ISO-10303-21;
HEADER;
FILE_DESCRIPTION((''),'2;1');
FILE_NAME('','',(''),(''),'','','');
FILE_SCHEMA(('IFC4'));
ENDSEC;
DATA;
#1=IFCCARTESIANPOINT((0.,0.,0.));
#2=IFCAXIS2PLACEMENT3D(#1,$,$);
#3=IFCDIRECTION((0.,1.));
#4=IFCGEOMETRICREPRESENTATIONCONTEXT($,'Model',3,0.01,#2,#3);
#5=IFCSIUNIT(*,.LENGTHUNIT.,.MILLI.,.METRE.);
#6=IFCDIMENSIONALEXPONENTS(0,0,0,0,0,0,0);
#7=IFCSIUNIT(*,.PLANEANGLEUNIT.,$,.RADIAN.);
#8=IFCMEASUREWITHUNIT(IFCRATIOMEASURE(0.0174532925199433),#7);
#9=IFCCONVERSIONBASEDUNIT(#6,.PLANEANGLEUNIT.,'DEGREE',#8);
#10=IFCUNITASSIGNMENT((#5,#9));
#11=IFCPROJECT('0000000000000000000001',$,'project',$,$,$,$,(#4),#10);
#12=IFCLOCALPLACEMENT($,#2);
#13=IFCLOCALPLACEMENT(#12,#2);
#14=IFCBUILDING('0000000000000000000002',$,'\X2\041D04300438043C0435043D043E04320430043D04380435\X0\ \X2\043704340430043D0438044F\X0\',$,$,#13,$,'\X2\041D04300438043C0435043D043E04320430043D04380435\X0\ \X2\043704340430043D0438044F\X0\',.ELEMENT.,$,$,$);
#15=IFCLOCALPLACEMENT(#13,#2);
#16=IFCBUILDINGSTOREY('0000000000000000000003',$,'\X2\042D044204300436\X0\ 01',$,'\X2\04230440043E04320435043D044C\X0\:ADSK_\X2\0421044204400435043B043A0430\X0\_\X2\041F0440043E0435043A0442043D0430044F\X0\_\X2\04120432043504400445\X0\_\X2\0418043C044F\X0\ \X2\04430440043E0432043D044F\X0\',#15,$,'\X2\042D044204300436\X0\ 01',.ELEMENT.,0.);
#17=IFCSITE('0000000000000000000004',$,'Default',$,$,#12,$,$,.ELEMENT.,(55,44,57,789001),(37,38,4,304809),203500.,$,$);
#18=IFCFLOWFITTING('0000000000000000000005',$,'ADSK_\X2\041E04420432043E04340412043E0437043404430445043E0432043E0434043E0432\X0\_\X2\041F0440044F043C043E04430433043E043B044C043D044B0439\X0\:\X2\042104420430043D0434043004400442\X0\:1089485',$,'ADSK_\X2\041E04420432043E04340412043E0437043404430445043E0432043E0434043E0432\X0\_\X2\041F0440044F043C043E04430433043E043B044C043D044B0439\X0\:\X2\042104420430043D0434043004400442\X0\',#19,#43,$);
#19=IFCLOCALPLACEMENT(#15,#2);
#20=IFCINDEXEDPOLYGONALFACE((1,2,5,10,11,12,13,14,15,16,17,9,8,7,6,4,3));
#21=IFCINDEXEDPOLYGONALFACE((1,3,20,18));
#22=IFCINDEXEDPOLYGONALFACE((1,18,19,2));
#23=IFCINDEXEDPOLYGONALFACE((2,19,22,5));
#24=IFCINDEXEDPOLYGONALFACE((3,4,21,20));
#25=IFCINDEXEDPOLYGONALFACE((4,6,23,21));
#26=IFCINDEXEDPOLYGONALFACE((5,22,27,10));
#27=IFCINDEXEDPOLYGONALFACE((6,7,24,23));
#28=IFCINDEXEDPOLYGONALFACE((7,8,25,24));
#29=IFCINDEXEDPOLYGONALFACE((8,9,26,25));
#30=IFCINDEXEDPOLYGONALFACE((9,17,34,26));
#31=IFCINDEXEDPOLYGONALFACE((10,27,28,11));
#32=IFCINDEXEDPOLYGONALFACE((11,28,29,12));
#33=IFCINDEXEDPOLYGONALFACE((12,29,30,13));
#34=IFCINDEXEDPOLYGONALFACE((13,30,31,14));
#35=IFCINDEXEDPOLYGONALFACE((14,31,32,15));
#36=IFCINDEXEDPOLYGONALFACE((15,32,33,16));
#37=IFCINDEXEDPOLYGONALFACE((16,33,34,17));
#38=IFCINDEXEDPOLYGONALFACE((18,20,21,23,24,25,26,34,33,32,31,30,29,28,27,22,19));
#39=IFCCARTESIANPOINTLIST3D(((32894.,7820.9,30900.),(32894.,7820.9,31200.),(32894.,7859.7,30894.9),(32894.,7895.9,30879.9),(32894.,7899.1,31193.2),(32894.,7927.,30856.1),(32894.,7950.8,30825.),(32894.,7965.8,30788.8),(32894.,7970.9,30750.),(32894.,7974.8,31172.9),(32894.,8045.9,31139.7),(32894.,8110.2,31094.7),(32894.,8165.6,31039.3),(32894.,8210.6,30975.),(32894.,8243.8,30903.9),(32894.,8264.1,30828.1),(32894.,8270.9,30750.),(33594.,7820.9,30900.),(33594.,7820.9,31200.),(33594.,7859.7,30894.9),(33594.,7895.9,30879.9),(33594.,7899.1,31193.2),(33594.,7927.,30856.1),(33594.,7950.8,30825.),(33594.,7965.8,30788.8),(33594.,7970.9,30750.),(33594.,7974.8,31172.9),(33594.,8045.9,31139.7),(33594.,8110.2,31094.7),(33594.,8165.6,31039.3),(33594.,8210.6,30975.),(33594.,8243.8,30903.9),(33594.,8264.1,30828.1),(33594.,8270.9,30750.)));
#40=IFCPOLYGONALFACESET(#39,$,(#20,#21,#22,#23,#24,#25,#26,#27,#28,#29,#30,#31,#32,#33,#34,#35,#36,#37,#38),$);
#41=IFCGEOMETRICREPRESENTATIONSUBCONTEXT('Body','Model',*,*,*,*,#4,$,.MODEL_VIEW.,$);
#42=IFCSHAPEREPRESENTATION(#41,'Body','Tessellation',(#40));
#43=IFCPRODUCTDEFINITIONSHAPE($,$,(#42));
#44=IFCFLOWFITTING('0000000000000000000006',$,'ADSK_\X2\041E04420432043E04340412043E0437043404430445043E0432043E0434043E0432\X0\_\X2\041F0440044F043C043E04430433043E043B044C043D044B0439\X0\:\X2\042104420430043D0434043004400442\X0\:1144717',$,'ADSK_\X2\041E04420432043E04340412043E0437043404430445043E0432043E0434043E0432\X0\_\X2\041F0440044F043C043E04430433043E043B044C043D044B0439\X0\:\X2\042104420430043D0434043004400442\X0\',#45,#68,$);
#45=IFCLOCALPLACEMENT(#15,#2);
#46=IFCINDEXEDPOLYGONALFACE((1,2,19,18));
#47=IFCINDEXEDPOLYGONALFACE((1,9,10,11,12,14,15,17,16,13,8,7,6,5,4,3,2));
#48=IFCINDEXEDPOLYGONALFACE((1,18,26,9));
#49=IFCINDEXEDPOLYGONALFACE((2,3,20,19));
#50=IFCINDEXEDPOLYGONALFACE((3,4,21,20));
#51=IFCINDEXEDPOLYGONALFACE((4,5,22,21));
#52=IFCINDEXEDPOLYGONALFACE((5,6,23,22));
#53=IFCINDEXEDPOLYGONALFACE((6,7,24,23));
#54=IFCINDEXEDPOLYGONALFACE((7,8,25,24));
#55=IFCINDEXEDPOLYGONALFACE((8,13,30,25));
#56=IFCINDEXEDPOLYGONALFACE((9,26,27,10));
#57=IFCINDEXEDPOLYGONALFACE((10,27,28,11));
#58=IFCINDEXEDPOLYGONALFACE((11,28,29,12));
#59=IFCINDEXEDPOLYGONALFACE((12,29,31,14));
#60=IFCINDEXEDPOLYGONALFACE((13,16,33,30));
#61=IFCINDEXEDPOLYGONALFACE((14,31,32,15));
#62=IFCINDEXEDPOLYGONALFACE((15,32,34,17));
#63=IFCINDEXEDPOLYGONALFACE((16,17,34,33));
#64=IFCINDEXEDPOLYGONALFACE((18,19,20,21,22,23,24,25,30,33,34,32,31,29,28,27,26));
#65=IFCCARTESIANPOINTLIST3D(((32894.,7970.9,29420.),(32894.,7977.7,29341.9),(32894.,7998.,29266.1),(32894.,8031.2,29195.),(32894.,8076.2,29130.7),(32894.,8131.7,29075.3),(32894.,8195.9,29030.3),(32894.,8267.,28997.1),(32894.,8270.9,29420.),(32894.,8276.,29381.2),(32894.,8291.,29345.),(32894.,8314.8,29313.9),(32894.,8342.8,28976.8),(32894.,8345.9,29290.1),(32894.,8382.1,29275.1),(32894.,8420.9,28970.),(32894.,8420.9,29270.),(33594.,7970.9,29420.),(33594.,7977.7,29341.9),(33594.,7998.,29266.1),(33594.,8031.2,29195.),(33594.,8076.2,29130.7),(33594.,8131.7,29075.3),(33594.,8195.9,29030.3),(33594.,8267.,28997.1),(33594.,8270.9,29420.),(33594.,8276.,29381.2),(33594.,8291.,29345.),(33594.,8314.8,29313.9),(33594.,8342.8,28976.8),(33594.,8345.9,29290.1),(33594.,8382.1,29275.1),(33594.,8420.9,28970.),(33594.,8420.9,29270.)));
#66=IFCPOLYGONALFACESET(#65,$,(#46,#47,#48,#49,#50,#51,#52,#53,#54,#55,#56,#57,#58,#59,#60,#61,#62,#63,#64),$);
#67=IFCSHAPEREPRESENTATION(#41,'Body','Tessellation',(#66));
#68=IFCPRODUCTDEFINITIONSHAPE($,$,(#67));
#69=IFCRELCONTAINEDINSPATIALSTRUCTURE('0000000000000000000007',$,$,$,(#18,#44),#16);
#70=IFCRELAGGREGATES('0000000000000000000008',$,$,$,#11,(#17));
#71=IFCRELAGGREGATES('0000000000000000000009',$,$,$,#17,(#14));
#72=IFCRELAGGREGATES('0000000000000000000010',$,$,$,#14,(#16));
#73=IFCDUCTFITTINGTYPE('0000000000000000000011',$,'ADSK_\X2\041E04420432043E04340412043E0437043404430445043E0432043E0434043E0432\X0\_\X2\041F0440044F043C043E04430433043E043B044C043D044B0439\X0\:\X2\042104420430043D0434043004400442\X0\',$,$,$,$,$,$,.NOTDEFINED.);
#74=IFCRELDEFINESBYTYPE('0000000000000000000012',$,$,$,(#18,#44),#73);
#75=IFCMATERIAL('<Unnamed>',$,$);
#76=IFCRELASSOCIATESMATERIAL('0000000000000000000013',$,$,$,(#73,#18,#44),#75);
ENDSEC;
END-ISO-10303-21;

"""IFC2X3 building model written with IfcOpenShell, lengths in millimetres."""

from ifc_helpers import new_model, entity, si_unit, converted_unit, direction, frame, frame_2d, origin, place, context, subcontext, project, spatial, polyline, circle_curve, parameter, trimmed, segment, composite_curve, outline, extrude, source, transform, mapped, material, type_object, type_shapes, element, save


model = new_model("IFC2X3")

# Units and contexts
model_context = context("Model", 3, precision=0.01, world=origin(), true_north=direction((0.0, 1.0)))
body_context = subcontext(model_context, "Body", "Model", "MODEL_VIEW")
ifc_project = project(units=[si_unit("LENGTHUNIT", "METRE", prefix="MILLI"), converted_unit("PLANEANGLEUNIT", "DEGREE", entity("IfcRatioMeasure", 0.0174532925199433), si_unit("PLANEANGLEUNIT", "RADIAN"), dimensions=[0, 0, 0, 0, 0, 0, 0])], contexts=[model_context])

# Site, building, storey
site_placement = place(None, origin())
site = spatial("IfcSite", under=ifc_project, at=site_placement, Name="Default", CompositionType="ELEMENT", RefLatitude=(55, 44, 57, 789001), RefLongitude=(37, 38, 4, 304809), RefElevation=203500.0)
building_placement = place(site_placement, origin())
building = spatial("IfcBuilding", under=site, at=building_placement, Name="Наименование здания", LongName="Наименование здания", CompositionType="ELEMENT")
storey_placement = place(building_placement, origin())
storey = spatial("IfcBuildingStorey", under=building, at=storey_placement, Name="Этаж 01", ObjectType="Уровень:ADSK_Стрелка_Проектная_Вверх_Имя уровня", LongName="Этаж 01", CompositionType="ELEMENT", Elevation=0.0)

# Shared definitions
ifc_material_1 = material(Name="<Unnamed>")

# Flow fittings
duct_fitting_type_1 = type_object("IfcDuctFittingType", Name="ADSK_ОтводВоздуховодов_Прямоугольный:Стандарт", PredefinedType="NOTDEFINED", material=ifc_material_1)
shared_shape_1 = source(origin(), body_context, "Body", "SweptSolid", [
    extrude(outline(composite_curve([segment(polyline([(-300.0, -150.0), (0.0, -150.0)]), True, "CONTINUOUS"), segment(trimmed(circle_curve(frame_2d((150.0, -150.0), x_axis=(0.0, 1.0)), 150.0), [parameter(0.0)], [parameter(90.0)], True, "PARAMETER"), False, "CONTINUOUS"), segment(polyline([(150.0, 0.0), (150.0, 300.0)]), True, "CONTINUOUS"), segment(trimmed(circle_curve(frame_2d((150.0, -150.0), x_axis=(0.0, 1.0)), 450.0), [parameter(0.0)], [parameter(90.0)], True, "PARAMETER"), True, "CONTINUOUS")], self_intersect=False)), frame((-150.0, 150.0, -350.0), z_axis=(0.0, 0.0, 1.0), x_axis=(-1.0, 0.0, 0.0)), (0.0, 0.0, 1.0), 700.0),
])
type_shapes(duct_fitting_type_1, [shared_shape_1])
for number, where, z_axis, x_axis, name in (
    (1, (33244.0, 8120.9, 31050.0), (1.0, 0.0, 0.0), (0.0, 0.0, 1.0), "ADSK_ОтводВоздуховодов_Прямоугольный:Стандарт:1089485"),
    (2, (33244.0, 8120.9, 29120.0), (1.0, 0.0, 0.0), (0.0, 0.0, -1.0), "ADSK_ОтводВоздуховодов_Прямоугольный:Стандарт:1144717"),
):
    element("IfcFlowFitting", number, at=place(storey_placement, frame(where, z_axis=z_axis, x_axis=x_axis)), inside=storey, type_object=duct_fitting_type_1, material=ifc_material_1, Name=name, ObjectType="ADSK_ОтводВоздуховодов_Прямоугольный:Стандарт", context=body_context, shape_type="MappedRepresentation", body=[
        mapped(shared_shape_1, transform((0.0, 0.0, 0.0), scale=1.0)),
    ])

save(model, "model.ifc")
